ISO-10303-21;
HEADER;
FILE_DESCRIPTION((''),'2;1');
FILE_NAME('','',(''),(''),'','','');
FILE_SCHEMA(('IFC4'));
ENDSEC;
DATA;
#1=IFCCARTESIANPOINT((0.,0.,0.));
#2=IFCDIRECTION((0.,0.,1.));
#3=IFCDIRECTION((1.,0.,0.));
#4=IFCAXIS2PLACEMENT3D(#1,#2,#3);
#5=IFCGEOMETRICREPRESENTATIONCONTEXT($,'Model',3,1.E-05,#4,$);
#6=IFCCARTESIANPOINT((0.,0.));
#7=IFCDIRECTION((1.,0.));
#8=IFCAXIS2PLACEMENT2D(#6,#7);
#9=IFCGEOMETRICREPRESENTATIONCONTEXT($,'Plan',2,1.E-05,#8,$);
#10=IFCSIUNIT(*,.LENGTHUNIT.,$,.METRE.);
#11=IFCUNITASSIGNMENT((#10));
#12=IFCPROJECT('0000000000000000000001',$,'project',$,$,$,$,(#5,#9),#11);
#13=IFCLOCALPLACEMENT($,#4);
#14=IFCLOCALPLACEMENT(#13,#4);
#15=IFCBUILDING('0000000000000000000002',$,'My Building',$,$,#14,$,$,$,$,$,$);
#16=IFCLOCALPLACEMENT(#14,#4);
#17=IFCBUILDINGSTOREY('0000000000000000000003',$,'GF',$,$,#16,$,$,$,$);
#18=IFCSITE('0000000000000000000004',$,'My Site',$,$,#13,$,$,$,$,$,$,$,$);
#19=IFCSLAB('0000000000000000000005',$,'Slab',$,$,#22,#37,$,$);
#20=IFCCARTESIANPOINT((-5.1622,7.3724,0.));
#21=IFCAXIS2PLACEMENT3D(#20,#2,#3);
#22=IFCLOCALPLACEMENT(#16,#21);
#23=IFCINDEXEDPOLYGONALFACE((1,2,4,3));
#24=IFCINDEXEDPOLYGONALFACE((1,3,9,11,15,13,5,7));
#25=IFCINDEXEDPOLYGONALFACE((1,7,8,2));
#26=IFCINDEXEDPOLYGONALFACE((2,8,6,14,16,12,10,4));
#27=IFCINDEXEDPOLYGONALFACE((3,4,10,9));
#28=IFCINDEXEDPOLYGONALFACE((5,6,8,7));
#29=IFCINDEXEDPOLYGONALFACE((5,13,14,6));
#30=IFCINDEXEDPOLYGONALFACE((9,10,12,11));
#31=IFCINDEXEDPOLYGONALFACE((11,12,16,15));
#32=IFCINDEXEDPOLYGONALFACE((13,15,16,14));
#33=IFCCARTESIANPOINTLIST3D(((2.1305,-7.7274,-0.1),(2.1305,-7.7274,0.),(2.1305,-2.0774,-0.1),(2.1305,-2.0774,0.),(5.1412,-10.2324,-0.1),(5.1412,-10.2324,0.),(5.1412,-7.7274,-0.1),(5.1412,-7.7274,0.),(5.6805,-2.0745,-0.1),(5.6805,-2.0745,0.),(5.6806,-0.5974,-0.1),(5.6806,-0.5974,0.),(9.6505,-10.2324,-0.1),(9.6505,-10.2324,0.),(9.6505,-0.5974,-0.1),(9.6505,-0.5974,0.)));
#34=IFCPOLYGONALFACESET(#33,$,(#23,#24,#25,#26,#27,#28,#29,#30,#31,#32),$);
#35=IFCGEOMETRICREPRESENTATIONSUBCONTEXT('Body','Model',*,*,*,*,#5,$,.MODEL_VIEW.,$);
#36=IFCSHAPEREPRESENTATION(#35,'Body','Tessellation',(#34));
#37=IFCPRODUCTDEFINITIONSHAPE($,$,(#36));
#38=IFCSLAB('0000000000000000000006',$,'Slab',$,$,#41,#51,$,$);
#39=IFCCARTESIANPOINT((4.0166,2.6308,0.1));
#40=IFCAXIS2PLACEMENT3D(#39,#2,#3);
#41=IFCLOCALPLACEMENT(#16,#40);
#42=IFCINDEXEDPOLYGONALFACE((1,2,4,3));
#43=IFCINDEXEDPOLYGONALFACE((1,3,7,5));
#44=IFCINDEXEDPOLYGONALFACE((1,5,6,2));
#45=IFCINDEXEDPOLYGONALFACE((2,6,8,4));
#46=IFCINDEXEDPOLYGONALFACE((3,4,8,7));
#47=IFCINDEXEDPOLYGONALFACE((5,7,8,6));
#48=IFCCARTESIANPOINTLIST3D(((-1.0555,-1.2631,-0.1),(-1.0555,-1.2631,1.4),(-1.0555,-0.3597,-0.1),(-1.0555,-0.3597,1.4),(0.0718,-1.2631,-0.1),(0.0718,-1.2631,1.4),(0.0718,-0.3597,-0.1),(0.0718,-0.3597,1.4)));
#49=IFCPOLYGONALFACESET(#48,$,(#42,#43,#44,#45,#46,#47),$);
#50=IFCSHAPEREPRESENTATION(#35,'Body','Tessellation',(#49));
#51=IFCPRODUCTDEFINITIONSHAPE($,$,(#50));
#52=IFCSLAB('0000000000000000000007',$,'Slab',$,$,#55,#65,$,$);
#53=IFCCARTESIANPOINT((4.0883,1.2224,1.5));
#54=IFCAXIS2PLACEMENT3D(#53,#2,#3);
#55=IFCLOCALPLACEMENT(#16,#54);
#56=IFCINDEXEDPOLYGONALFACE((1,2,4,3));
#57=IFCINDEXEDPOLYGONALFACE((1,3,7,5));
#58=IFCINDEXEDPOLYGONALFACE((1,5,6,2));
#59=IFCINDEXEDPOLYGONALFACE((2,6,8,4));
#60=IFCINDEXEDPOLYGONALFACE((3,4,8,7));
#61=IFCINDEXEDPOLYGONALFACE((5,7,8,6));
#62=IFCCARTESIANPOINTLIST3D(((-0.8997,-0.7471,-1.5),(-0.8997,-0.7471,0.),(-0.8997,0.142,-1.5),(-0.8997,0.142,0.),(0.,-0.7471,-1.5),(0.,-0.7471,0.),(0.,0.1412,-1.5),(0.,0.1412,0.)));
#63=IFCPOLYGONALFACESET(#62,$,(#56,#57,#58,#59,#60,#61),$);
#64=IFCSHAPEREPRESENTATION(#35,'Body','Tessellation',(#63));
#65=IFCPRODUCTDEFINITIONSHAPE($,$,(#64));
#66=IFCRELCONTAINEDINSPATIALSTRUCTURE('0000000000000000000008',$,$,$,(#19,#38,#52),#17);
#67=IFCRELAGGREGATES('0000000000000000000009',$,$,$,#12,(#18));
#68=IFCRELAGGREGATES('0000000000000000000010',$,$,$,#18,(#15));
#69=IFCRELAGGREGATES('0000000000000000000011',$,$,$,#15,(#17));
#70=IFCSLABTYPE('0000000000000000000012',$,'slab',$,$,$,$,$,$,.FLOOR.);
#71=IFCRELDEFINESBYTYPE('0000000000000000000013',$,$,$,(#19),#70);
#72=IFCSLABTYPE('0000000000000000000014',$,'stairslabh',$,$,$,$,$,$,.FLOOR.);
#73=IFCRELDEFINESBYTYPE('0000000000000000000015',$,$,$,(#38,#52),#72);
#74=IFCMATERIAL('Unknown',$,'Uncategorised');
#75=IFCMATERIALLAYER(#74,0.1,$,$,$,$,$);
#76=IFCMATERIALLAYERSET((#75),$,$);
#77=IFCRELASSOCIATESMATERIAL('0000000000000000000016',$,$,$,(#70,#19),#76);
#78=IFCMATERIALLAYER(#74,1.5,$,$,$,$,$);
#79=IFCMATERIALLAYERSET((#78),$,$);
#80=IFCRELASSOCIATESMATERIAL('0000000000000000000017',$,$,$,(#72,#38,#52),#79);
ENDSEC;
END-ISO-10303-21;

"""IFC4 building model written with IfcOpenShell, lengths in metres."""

from ifc_helpers import new_model, si_unit, frame, origin_with_axes, origin_2d_with_axis, place, context, subcontext, project, spatial, indexed_curve, outline, extrude, material, layer, layer_set, layer_usage, type_object, element, save


model = new_model("IFC4")

# Units and contexts
model_context = context("Model", 3, precision=1e-05, world=origin_with_axes())
plan_context = context("Plan", 2, precision=1e-05, world=origin_2d_with_axis())
body_context_1 = subcontext(model_context, "Body", "Model", "MODEL_VIEW")
ifc_project = project(units=[si_unit("LENGTHUNIT", "METRE")], contexts=[model_context, plan_context])

# Site, building, storey
site_placement = place(None, origin_with_axes())
site = spatial("IfcSite", under=ifc_project, at=site_placement, Name="My Site")
building_placement = place(site_placement, origin_with_axes())
building = spatial("IfcBuilding", under=site, at=building_placement, Name="My Building")
storey_placement = place(building_placement, origin_with_axes())
storey = spatial("IfcBuildingStorey", under=building, at=storey_placement, Name="GF")

# Slabs
ifc_material = material(Name="Unknown", Category="Uncategorised")
ifc_layer_1 = layer(ifc_material, 0.1)
ifc_layer_set_1 = layer_set([ifc_layer_1])
ifc_layer_usage_1 = layer_usage(ifc_layer_set_1, "AXIS3", "POSITIVE", -0.1)
slab_type_1 = type_object("IfcSlabType", Name="slab", PredefinedType="FLOOR", material=ifc_layer_set_1)
slab_1_placement = place(storey_placement, frame((-5.1622, 7.3724, 0.0), z_axis=(0.0, 0.0, 1.0), x_axis=(1.0, 0.0, 0.0)))
element("IfcSlab", 1, at=slab_1_placement, inside=storey, type_object=slab_type_1, material=ifc_layer_usage_1, Name="Slab", context=body_context_1, shape_type="SweptSolid", body=[
    extrude(outline(indexed_curve([(2.1305, -2.0774), (2.1305, -7.7274), (5.1412, -7.7274), (5.1412, -10.2324), (9.6505, -10.2324), (9.6505, -0.5974), (5.6806, -0.5974), (5.6805, -2.0745), (2.1305, -2.0774)])), frame((0.0, 0.0, -0.1), z_axis=(0.0, 0.0, 1.0), x_axis=(1.0, 0.0, 0.0)), (0.0, 0.0, 1.0), 0.1),
])
ifc_layer_2 = layer(ifc_material, 1.5)
ifc_layer_set_2 = layer_set([ifc_layer_2])
ifc_layer_usage_2 = layer_usage(ifc_layer_set_2, "AXIS3", "POSITIVE", -0.1)
slab_type_2 = type_object("IfcSlabType", Name="stairslabh", PredefinedType="FLOOR", material=ifc_layer_set_2)
slab_2_placement = place(storey_placement, frame((4.0166, 2.6308, 0.1), z_axis=(0.0, 0.0, 1.0), x_axis=(1.0, 0.0, 0.0)))
element("IfcSlab", 2, at=slab_2_placement, inside=storey, type_object=slab_type_2, material=ifc_layer_usage_2, Name="Slab", context=body_context_1, shape_type="SweptSolid", body=[
    extrude(outline(indexed_curve([(0.0718, -1.2631), (0.0718, -0.3597), (-1.0555, -0.3597), (-1.0555, -1.2631), (0.0718, -1.2631)])), frame((0.0, 0.0, -0.1), z_axis=(0.0, 0.0, 1.0), x_axis=(1.0, 0.0, 0.0)), (0.0, 0.0, 1.0), 1.5),
])
ifc_layer_usage_3 = layer_usage(ifc_layer_set_2, "AXIS3", "POSITIVE", -1.5)
slab_3_placement = place(storey_placement, frame((4.0883, 1.2224, 1.5), z_axis=(0.0, 0.0, 1.0), x_axis=(1.0, 0.0, 0.0)))
element("IfcSlab", 3, at=slab_3_placement, inside=storey, type_object=slab_type_2, material=ifc_layer_usage_3, Name="Slab", context=body_context_1, shape_type="SweptSolid", body=[
    extrude(outline(indexed_curve([(-0.8997, 0.142), (-0.8997, -0.7471), (0.0, -0.7471), (0.0, 0.1412), (-0.8997, 0.142)])), frame((0.0, 0.0, -1.5), z_axis=(0.0, 0.0, 1.0), x_axis=(1.0, 0.0, 0.0)), (0.0, 0.0, 1.0), 1.5),
])

save(model, "model.ifc")
